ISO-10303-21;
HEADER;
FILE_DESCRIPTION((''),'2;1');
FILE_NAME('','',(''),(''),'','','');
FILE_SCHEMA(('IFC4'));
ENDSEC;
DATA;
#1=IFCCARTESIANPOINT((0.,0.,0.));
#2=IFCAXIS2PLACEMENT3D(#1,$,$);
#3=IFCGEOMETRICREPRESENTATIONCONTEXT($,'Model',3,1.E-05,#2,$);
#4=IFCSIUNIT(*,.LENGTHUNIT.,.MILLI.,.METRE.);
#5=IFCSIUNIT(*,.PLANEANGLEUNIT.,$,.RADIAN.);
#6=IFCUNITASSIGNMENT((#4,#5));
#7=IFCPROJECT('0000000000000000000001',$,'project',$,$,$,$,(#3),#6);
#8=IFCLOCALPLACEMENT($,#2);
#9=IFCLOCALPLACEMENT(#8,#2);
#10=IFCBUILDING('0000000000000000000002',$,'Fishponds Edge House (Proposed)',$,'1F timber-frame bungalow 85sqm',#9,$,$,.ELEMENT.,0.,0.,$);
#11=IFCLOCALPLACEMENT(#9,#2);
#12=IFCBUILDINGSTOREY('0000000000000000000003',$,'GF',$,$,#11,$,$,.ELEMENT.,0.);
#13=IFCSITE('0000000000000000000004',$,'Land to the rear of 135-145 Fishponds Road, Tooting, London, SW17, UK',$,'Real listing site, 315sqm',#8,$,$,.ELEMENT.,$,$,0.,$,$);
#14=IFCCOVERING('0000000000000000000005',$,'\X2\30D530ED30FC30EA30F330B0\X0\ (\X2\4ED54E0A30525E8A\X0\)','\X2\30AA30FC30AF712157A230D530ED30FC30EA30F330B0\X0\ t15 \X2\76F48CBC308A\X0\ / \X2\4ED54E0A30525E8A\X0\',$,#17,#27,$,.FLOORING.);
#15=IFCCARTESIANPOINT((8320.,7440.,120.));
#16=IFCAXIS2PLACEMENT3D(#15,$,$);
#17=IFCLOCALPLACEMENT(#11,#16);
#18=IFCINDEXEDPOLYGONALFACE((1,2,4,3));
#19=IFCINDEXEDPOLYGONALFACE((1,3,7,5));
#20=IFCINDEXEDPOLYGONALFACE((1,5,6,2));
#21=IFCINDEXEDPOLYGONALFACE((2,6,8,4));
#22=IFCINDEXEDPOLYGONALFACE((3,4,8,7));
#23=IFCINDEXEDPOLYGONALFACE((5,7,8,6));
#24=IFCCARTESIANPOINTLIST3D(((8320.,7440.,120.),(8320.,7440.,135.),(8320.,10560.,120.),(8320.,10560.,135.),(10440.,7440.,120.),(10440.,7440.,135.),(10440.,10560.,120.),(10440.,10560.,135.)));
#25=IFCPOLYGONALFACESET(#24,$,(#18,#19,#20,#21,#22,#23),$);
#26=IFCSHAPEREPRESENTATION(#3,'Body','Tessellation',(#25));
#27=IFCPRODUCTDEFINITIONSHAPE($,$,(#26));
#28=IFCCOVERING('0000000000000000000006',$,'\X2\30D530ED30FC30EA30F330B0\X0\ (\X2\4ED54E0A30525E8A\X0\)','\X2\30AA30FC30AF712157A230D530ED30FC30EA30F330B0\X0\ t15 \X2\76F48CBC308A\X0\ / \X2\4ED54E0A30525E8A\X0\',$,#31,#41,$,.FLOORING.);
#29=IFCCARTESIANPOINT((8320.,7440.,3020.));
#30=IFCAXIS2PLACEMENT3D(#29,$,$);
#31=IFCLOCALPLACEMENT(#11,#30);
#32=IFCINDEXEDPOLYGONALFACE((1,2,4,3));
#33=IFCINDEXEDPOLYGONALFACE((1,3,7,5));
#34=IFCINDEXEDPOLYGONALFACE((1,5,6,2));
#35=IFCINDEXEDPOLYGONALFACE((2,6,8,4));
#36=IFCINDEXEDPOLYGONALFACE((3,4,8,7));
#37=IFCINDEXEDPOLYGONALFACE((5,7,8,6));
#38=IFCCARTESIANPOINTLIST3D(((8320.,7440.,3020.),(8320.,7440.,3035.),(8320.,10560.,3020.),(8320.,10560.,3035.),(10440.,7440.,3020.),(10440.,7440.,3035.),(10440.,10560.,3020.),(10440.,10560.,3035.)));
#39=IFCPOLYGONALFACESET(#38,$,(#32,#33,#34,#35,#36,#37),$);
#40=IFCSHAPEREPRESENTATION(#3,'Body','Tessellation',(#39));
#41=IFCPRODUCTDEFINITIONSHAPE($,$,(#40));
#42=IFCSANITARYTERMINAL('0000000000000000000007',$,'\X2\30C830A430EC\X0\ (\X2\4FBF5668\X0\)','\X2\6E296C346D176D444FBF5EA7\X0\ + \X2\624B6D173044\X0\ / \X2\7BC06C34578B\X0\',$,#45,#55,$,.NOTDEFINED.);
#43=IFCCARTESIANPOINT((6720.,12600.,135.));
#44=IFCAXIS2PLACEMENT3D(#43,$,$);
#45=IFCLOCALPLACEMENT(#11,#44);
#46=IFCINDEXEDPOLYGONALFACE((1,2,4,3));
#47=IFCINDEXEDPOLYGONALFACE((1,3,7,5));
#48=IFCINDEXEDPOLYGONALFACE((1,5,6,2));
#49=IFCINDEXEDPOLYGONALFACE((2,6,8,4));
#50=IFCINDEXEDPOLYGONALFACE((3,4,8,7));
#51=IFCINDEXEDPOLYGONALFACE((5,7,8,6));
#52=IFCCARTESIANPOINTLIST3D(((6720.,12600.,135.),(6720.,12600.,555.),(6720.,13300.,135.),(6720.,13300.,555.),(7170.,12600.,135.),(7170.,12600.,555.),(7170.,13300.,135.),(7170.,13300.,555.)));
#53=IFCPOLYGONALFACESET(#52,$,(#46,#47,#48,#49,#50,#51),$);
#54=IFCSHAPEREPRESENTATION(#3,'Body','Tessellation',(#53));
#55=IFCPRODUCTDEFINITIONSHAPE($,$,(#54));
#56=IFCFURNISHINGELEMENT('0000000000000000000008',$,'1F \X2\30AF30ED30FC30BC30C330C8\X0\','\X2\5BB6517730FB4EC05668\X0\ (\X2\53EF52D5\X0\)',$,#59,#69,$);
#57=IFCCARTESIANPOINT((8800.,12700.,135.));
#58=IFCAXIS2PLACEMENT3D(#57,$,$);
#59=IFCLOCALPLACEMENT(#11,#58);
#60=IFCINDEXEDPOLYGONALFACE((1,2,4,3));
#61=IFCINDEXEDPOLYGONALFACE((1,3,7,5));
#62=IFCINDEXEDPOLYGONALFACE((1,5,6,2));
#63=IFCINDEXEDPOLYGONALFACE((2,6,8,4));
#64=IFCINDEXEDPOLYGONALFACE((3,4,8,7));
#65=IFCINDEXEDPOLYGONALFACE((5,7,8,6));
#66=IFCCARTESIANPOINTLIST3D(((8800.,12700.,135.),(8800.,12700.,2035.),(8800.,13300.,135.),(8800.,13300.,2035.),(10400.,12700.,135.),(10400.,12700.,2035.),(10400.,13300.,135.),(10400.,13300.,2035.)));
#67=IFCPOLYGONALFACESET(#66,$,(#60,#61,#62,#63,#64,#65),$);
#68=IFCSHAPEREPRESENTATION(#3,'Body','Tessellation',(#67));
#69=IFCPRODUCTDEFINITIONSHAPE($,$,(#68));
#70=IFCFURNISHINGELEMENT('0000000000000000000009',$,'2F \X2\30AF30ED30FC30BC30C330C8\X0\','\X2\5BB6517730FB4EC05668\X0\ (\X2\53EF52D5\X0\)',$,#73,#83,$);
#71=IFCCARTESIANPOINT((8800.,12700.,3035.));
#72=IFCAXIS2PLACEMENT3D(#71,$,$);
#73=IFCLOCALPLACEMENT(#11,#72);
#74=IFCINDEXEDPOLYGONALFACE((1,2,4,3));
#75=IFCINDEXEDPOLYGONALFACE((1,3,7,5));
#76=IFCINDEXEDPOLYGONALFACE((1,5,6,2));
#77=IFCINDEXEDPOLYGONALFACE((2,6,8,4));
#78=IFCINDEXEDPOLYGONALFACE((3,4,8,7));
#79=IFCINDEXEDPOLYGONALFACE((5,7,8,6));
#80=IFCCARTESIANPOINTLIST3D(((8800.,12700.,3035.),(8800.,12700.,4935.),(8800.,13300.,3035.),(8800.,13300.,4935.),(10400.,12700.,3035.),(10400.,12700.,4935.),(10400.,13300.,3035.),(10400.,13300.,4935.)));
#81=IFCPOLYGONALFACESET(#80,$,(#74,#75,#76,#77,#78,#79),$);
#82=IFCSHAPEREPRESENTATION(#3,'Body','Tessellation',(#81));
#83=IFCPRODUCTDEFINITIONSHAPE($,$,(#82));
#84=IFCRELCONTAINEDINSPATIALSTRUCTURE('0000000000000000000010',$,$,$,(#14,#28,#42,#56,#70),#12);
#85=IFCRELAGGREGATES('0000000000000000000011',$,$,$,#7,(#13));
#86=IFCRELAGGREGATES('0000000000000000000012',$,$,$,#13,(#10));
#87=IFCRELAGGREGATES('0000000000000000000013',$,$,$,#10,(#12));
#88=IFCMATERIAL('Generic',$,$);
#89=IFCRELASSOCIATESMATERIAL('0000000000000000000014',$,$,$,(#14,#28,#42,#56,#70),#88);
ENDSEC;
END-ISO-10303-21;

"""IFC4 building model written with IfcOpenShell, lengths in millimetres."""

from ifc_helpers import new_model, si_unit, frame, frame_2d, origin, place, context, project, spatial, rectangle, extrude, material, element, save


model = new_model("IFC4")

# Units and contexts
model_context = context("Model", 3, precision=1e-05, world=origin())
ifc_project = project(units=[si_unit("LENGTHUNIT", "METRE", prefix="MILLI"), si_unit("PLANEANGLEUNIT", "RADIAN")], contexts=[model_context])

# Site, building, storey
site_placement = place(None, origin())
site = spatial("IfcSite", under=ifc_project, at=site_placement, Name="Land to the rear of 135-145 Fishponds Road, Tooting, London, SW17, UK", ObjectType="Real listing site, 315sqm", CompositionType="ELEMENT", RefElevation=0.0)
building_placement = place(site_placement, origin())
building = spatial("IfcBuilding", under=site, at=building_placement, Name="Fishponds Edge House (Proposed)", ObjectType="1F timber-frame bungalow 85sqm", CompositionType="ELEMENT", ElevationOfRefHeight=0.0, ElevationOfTerrain=0.0)
storey_placement = place(building_placement, origin())
storey = spatial("IfcBuildingStorey", under=building, at=storey_placement, Name="GF", CompositionType="ELEMENT", Elevation=0.0)

# Shared definitions
ifc_material_1 = material(Name="Generic")

# Coverings
covering_1_placement = place(storey_placement, frame((8320.0, 7440.0, 120.0)))
element("IfcCovering", 1, at=covering_1_placement, inside=storey, material=ifc_material_1, Name="フローリング (仕上げ床)", Description="オーク無垢フローリング t15 直貼り / 仕上げ床", PredefinedType="FLOORING", context=model_context, shape_type="SweptSolid", body=[
    extrude(rectangle(XDim=2120.0, YDim=3120.0, at=frame_2d((1060.0, 1560.0))), frame((8320.0, 7440.0, 120.0)), (0.0, 0.0, 1.0), 15.0),
])
covering_2_placement = place(storey_placement, frame((8320.0, 7440.0, 3020.0)))
element("IfcCovering", 2, at=covering_2_placement, inside=storey, material=ifc_material_1, Name="フローリング (仕上げ床)", Description="オーク無垢フローリング t15 直貼り / 仕上げ床", PredefinedType="FLOORING", context=model_context, shape_type="SweptSolid", body=[
    extrude(rectangle(XDim=2120.0, YDim=3120.0, at=frame_2d((1060.0, 1560.0))), frame((8320.0, 7440.0, 3020.0)), (0.0, 0.0, 1.0), 15.0),
])

# Sanitary terminal
sanitary_terminal_placement = place(storey_placement, frame((6720.0, 12600.0, 135.0)))
element("IfcSanitaryTerminal", 3, at=sanitary_terminal_placement, inside=storey, material=ifc_material_1, Name="トイレ (便器)", Description="温水洗浄便座 + 手洗い / 節水型", PredefinedType="NOTDEFINED", context=model_context, shape_type="SweptSolid", body=[
    extrude(rectangle(XDim=450.0, YDim=700.0, at=frame_2d((225.0, 350.0))), frame((6720.0, 12600.0, 135.0)), (0.0, 0.0, 1.0), 420.0),
])

# Furnishing elements
furnishing_1_placement = place(storey_placement, frame((8800.0, 12700.0, 135.0)))
element("IfcFurnishingElement", 4, at=furnishing_1_placement, inside=storey, material=ifc_material_1, Name="1F クローゼット", Description="家具・什器 (可動)", context=model_context, shape_type="SweptSolid", body=[
    extrude(rectangle(XDim=1600.0, YDim=600.0, at=frame_2d((800.0, 300.0))), frame((8800.0, 12700.0, 135.0)), (0.0, 0.0, 1.0), 1900.0),
])
furnishing_2_placement = place(storey_placement, frame((8800.0, 12700.0, 3035.0)))
element("IfcFurnishingElement", 5, at=furnishing_2_placement, inside=storey, material=ifc_material_1, Name="2F クローゼット", Description="家具・什器 (可動)", context=model_context, shape_type="SweptSolid", body=[
    extrude(rectangle(XDim=1600.0, YDim=600.0, at=frame_2d((800.0, 300.0))), frame((8800.0, 12700.0, 3035.0)), (0.0, 0.0, 1.0), 1900.0),
])

save(model, "model.ifc")
